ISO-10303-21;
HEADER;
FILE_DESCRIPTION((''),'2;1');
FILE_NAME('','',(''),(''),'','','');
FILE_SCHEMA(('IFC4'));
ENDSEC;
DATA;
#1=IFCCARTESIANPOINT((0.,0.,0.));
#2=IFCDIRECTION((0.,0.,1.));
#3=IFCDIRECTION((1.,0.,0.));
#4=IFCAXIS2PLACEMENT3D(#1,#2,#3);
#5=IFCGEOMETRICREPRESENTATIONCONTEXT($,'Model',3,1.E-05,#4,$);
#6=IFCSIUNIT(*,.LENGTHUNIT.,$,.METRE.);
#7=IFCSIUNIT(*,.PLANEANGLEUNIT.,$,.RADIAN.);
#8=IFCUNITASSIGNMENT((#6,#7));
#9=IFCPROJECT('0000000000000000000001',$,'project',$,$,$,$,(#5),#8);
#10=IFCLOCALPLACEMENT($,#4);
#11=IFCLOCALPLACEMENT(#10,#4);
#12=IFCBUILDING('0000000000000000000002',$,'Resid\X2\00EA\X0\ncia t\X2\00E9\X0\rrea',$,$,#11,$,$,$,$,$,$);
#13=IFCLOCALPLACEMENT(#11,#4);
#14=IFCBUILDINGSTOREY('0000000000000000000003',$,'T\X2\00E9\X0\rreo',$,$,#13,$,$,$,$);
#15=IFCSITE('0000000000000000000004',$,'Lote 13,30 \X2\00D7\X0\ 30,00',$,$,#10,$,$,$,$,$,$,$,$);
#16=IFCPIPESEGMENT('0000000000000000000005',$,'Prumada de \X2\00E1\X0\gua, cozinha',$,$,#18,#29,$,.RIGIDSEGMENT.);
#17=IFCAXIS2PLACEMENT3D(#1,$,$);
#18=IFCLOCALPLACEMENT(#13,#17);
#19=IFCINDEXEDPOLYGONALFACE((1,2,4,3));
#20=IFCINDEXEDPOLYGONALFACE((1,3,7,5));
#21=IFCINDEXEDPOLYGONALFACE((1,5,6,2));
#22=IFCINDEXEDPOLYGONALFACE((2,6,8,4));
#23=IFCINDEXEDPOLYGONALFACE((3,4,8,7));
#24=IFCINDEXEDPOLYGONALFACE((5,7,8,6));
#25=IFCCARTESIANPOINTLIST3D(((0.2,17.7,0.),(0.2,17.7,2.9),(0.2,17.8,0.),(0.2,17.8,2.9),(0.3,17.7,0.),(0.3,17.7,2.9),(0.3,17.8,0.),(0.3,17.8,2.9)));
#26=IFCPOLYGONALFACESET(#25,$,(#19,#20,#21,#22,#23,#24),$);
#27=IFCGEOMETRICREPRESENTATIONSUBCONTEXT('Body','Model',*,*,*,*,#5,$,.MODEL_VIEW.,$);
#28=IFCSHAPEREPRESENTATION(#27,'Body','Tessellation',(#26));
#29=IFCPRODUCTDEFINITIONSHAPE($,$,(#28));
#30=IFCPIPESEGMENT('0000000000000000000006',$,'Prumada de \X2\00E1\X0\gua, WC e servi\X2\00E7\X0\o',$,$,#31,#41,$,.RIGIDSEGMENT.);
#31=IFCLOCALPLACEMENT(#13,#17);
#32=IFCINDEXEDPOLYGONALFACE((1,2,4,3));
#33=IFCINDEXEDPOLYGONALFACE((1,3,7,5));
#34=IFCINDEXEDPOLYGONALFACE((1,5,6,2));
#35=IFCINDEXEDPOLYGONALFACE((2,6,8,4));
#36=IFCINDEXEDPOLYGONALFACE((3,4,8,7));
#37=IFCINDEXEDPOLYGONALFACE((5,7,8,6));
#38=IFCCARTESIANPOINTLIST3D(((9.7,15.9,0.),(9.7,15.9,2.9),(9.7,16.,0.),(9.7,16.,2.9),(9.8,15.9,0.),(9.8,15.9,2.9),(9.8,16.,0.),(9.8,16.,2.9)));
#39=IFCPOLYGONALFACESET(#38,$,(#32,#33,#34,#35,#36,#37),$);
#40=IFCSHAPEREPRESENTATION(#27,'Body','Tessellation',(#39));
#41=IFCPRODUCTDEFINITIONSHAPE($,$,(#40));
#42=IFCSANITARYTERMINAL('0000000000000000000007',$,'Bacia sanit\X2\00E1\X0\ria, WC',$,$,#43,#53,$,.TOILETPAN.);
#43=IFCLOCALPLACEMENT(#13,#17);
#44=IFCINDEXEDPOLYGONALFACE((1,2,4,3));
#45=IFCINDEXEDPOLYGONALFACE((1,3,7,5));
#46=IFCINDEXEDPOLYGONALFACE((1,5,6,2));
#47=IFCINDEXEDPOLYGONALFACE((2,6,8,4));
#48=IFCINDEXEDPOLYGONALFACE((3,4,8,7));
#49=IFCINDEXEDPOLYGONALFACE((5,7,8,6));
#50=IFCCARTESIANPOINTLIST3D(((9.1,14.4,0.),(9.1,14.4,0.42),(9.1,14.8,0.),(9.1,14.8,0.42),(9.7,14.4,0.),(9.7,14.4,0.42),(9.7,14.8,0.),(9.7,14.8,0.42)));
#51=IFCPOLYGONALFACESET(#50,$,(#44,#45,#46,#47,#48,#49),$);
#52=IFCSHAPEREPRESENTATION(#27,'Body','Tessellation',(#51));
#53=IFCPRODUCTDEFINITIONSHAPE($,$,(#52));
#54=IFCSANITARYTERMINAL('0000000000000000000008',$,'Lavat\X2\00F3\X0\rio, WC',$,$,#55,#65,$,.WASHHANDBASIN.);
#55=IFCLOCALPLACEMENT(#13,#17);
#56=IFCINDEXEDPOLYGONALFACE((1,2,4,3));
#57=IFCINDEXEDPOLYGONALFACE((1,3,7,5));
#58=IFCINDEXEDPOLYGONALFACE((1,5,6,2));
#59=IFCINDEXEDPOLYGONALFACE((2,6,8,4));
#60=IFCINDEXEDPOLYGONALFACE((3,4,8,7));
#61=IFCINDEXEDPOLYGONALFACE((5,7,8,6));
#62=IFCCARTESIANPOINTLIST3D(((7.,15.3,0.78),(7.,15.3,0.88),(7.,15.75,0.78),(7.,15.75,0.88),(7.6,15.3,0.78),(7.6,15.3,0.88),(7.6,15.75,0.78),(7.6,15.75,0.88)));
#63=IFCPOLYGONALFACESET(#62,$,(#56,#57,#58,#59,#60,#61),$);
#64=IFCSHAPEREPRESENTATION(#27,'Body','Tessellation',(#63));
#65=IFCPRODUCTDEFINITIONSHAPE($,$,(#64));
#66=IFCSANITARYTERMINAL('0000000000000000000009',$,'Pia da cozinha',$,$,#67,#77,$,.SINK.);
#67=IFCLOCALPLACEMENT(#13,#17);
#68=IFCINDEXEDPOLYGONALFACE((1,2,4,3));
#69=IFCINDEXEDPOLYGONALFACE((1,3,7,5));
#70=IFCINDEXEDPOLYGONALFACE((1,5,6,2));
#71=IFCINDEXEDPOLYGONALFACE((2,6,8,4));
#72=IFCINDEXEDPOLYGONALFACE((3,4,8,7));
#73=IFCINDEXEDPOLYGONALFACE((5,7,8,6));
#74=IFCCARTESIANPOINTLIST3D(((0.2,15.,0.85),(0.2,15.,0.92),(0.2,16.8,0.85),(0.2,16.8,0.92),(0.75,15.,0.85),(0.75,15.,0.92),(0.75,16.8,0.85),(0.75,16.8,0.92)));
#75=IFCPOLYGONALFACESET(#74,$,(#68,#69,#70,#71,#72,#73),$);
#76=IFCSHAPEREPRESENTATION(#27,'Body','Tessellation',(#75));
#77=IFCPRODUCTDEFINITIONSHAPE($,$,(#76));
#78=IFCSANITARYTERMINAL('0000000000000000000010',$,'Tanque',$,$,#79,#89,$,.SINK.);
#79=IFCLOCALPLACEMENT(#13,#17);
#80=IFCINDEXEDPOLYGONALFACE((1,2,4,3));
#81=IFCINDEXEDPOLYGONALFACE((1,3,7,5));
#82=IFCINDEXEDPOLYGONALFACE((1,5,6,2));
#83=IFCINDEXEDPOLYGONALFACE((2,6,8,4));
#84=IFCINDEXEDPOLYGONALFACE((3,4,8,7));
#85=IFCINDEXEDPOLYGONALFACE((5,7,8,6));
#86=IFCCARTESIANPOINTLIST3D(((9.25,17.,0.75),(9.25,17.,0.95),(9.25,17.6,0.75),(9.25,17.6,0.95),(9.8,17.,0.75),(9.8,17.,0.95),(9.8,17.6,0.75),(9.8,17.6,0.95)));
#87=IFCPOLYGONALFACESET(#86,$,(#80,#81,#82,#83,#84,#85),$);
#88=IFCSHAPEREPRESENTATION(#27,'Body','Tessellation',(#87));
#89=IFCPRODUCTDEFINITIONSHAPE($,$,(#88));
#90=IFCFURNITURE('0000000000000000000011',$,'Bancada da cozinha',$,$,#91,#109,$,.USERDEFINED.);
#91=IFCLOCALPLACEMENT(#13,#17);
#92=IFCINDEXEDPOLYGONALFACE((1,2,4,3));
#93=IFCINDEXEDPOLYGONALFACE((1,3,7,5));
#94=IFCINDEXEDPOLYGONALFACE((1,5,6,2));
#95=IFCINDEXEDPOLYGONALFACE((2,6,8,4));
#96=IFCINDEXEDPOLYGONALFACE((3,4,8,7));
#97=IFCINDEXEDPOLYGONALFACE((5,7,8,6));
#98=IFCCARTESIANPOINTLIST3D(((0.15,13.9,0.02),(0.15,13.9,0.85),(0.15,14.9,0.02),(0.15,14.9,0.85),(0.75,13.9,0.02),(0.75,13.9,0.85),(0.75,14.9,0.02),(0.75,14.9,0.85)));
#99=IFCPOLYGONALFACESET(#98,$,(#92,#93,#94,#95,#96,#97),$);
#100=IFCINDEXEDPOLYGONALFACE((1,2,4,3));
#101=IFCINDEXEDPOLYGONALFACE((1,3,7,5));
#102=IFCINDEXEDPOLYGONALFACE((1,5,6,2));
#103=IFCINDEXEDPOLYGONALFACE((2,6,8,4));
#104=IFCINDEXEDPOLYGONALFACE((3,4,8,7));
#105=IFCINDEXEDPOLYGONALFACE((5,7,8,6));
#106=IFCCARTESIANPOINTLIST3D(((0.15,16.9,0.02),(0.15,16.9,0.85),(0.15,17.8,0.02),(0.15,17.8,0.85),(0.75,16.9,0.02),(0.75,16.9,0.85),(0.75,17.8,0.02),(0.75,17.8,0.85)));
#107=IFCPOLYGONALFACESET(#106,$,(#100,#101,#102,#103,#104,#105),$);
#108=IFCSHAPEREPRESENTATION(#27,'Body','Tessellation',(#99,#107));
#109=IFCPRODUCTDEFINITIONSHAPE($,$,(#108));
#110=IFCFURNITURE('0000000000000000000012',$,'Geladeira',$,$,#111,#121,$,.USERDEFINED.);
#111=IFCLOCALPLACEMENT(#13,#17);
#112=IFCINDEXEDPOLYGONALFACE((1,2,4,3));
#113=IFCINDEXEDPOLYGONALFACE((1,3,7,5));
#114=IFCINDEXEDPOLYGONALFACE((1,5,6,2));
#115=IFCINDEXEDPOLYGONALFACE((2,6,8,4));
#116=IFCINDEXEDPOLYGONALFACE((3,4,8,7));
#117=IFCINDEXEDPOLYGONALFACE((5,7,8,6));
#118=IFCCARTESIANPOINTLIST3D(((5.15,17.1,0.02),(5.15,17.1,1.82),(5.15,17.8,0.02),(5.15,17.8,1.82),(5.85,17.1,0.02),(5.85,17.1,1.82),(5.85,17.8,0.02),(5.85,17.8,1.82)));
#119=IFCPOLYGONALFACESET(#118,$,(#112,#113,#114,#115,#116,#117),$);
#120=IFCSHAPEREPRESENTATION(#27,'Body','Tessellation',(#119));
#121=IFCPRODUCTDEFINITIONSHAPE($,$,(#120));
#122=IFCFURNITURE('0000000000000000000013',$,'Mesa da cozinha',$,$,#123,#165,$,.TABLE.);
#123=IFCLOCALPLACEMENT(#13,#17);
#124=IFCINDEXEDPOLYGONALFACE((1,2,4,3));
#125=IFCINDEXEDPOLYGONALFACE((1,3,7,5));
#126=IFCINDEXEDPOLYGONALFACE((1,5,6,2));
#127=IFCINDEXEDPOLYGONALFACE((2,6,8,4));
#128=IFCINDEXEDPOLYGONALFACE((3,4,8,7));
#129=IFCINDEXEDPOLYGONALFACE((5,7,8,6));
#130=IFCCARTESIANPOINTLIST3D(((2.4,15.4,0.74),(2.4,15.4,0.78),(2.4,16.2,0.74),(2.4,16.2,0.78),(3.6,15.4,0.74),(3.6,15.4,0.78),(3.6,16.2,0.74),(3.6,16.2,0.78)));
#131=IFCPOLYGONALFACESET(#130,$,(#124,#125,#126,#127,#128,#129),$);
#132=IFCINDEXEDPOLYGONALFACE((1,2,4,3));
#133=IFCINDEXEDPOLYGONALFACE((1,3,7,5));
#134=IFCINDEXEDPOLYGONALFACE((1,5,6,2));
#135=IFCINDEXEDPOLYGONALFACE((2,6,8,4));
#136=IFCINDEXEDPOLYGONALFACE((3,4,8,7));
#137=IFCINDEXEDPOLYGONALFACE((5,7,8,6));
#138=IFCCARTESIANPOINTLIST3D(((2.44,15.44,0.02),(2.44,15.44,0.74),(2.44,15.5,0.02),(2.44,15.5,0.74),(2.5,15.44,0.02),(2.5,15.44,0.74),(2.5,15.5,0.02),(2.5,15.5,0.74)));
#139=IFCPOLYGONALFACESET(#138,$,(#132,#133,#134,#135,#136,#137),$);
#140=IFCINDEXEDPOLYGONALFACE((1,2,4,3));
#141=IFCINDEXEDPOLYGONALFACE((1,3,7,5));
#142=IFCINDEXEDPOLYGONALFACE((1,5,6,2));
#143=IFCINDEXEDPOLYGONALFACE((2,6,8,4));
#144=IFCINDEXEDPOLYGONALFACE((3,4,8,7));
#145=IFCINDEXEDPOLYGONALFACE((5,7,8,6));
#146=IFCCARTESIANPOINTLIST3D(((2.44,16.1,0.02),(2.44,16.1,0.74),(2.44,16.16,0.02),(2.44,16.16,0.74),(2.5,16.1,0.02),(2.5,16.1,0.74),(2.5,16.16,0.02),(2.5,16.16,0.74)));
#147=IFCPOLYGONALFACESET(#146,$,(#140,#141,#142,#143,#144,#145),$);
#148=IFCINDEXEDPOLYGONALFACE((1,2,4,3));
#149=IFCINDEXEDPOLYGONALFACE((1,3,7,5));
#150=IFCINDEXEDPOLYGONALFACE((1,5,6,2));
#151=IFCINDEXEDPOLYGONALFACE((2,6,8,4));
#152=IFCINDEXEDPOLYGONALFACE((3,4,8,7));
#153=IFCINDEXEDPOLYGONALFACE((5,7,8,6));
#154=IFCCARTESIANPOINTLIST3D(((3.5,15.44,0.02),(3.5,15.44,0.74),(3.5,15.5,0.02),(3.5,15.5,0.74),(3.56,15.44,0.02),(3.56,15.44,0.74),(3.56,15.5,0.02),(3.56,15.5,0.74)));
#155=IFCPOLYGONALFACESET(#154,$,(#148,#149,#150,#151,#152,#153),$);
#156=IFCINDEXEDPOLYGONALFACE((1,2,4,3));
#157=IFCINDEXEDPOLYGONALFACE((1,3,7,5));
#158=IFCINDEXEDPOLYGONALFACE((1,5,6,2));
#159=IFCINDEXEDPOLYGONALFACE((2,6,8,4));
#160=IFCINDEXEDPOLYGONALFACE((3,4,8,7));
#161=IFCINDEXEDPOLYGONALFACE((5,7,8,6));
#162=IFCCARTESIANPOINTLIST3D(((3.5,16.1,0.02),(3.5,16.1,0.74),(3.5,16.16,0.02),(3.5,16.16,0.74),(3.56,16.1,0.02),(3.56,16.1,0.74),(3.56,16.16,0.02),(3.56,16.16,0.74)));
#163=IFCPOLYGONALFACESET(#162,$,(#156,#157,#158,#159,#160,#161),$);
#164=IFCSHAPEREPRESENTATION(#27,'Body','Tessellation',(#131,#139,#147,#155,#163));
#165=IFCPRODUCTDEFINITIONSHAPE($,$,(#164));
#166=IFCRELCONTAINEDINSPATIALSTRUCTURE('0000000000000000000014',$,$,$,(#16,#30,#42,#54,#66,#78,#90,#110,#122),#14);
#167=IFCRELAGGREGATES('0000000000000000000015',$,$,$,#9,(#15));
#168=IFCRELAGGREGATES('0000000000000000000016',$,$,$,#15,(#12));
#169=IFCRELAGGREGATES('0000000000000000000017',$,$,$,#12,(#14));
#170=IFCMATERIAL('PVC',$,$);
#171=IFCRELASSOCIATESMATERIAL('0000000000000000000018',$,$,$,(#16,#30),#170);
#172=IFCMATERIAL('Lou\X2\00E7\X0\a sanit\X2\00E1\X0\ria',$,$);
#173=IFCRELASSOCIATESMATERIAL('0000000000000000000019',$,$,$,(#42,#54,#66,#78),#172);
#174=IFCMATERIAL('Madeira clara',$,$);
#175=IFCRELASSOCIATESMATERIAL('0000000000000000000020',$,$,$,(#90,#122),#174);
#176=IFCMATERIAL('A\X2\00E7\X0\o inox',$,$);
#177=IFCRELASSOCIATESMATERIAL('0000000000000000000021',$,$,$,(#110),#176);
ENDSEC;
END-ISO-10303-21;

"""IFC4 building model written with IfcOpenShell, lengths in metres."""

from ifc_helpers import new_model, si_unit, frame, origin_with_axes, place, context, subcontext, project, spatial, line, indexed_curve, outline, extrude, material, element, save


model = new_model("IFC4")

# Units and contexts
model_context = context("Model", 3, precision=1e-05, world=origin_with_axes())
body_context = subcontext(model_context, "Body", "Model", "MODEL_VIEW")
ifc_project = project(units=[si_unit("LENGTHUNIT", "METRE"), si_unit("PLANEANGLEUNIT", "RADIAN")], contexts=[model_context])

# Site, building, storey
site_placement = place(None, origin_with_axes())
site = spatial("IfcSite", under=ifc_project, at=site_placement, Name="Lote 13,30 × 30,00")
building_placement = place(site_placement, origin_with_axes())
building = spatial("IfcBuilding", under=site, at=building_placement, Name="Residência térrea")
storey_placement = place(building_placement, origin_with_axes())
storey = spatial("IfcBuildingStorey", under=building, at=storey_placement, Name="Térreo")

# Pipe segments
ifc_material_1 = material(Name="PVC")
pipe_segment_1_placement = place(storey_placement, frame((0.2, 17.7, 0.0), z_axis=(0.0, 0.0, 1.0), x_axis=(1.0, 0.0, 0.0)))
element("IfcPipeSegment", 1, at=pipe_segment_1_placement, inside=storey, material=ifc_material_1, Name="Prumada de água, cozinha", PredefinedType="RIGIDSEGMENT", context=body_context, shape_type="SweptSolid", body=[
    extrude(outline(indexed_curve([(0.0, 0.0), (0.1, 0.0), (0.1, 0.1), (0.0, 0.1)], segments=[line(1, 2, 3, 4, 1)])), origin_with_axes(), (0.0, 0.0, 1.0), 2.9),
])
pipe_segment_2_placement = place(storey_placement, frame((9.7, 15.9, 0.0), z_axis=(0.0, 0.0, 1.0), x_axis=(1.0, 0.0, 0.0)))
element("IfcPipeSegment", 2, at=pipe_segment_2_placement, inside=storey, material=ifc_material_1, Name="Prumada de água, WC e serviço", PredefinedType="RIGIDSEGMENT", context=body_context, shape_type="SweptSolid", body=[
    extrude(outline(indexed_curve([(0.0, 0.0), (0.1, 0.0), (0.1, 0.1), (0.0, 0.1)], segments=[line(1, 2, 3, 4, 1)])), origin_with_axes(), (0.0, 0.0, 1.0), 2.9),
])

# Sanitary terminals
ifc_material_2 = material(Name="Louça sanitária")
sanitary_terminal_1_placement = place(storey_placement, frame((9.1, 14.4, 0.0), z_axis=(0.0, 0.0, 1.0), x_axis=(1.0, 0.0, 0.0)))
element("IfcSanitaryTerminal", 3, at=sanitary_terminal_1_placement, inside=storey, material=ifc_material_2, Name="Bacia sanitária, WC", PredefinedType="TOILETPAN", context=body_context, shape_type="SweptSolid", body=[
    extrude(outline(indexed_curve([(0.0, 0.0), (0.6, 0.0), (0.6, 0.4), (0.0, 0.4)], segments=[line(1, 2, 3, 4, 1)])), origin_with_axes(), (0.0, 0.0, 1.0), 0.42),
])
sanitary_terminal_2_placement = place(storey_placement, frame((7.0, 15.3, 0.78), z_axis=(0.0, 0.0, 1.0), x_axis=(1.0, 0.0, 0.0)))
element("IfcSanitaryTerminal", 4, at=sanitary_terminal_2_placement, inside=storey, material=ifc_material_2, Name="Lavatório, WC", PredefinedType="WASHHANDBASIN", context=body_context, shape_type="SweptSolid", body=[
    extrude(outline(indexed_curve([(0.0, 0.0), (0.6, 0.0), (0.6, 0.45), (0.0, 0.45)], segments=[line(1, 2, 3, 4, 1)])), origin_with_axes(), (0.0, 0.0, 1.0), 0.1),
])
sanitary_terminal_3_placement = place(storey_placement, frame((0.2, 15.0, 0.85), z_axis=(0.0, 0.0, 1.0), x_axis=(1.0, 0.0, 0.0)))
element("IfcSanitaryTerminal", 5, at=sanitary_terminal_3_placement, inside=storey, material=ifc_material_2, Name="Pia da cozinha", PredefinedType="SINK", context=body_context, shape_type="SweptSolid", body=[
    extrude(outline(indexed_curve([(0.0, 0.0), (0.55, 0.0), (0.55, 1.8), (0.0, 1.8)], segments=[line(1, 2, 3, 4, 1)])), origin_with_axes(), (0.0, 0.0, 1.0), 0.07),
])
sanitary_terminal_4_placement = place(storey_placement, frame((9.25, 17.0, 0.75), z_axis=(0.0, 0.0, 1.0), x_axis=(1.0, 0.0, 0.0)))
element("IfcSanitaryTerminal", 6, at=sanitary_terminal_4_placement, inside=storey, material=ifc_material_2, Name="Tanque", PredefinedType="SINK", context=body_context, shape_type="SweptSolid", body=[
    extrude(outline(indexed_curve([(0.0, 0.0), (0.55, 0.0), (0.55, 0.6), (0.0, 0.6)], segments=[line(1, 2, 3, 4, 1)])), origin_with_axes(), (0.0, 0.0, 1.0), 0.2),
])

# Furniture
ifc_material_3 = material(Name="Madeira clara")
furniture_1_placement = place(storey_placement, frame((0.15, 13.9, 0.02), z_axis=(0.0, 0.0, 1.0), x_axis=(1.0, 0.0, 0.0)))
element("IfcFurniture", 7, at=furniture_1_placement, inside=storey, material=ifc_material_3, Name="Bancada da cozinha", PredefinedType="USERDEFINED", context=body_context, shape_type="SweptSolid", body=[
    extrude(outline(indexed_curve([(0.0, 0.0), (0.6, 0.0), (0.6, 1.0), (0.0, 1.0)], segments=[line(1, 2, 3, 4, 1)])), origin_with_axes(), (0.0, 0.0, 1.0), 0.83),
    extrude(outline(indexed_curve([(0.0, 3.0), (0.6, 3.0), (0.6, 3.9), (0.0, 3.9)], segments=[line(1, 2, 3, 4, 1)])), origin_with_axes(), (0.0, 0.0, 1.0), 0.83),
])
ifc_material_4 = material(Name="Aço inox")
furniture_2_placement = place(storey_placement, frame((5.15, 17.1, 0.02), z_axis=(0.0, 0.0, 1.0), x_axis=(1.0, 0.0, 0.0)))
element("IfcFurniture", 8, at=furniture_2_placement, inside=storey, material=ifc_material_4, Name="Geladeira", PredefinedType="USERDEFINED", context=body_context, shape_type="SweptSolid", body=[
    extrude(outline(indexed_curve([(0.0, 0.0), (0.7, 0.0), (0.7, 0.7), (0.0, 0.7)], segments=[line(1, 2, 3, 4, 1)])), origin_with_axes(), (0.0, 0.0, 1.0), 1.8),
])
furniture_3_placement = place(storey_placement, frame((2.4, 15.4, 0.02), z_axis=(0.0, 0.0, 1.0), x_axis=(1.0, 0.0, 0.0)))
element("IfcFurniture", 9, at=furniture_3_placement, inside=storey, material=ifc_material_3, Name="Mesa da cozinha", PredefinedType="TABLE", context=body_context, shape_type="SweptSolid", body=[
    extrude(outline(indexed_curve([(0.0, 0.0), (1.2, 0.0), (1.2, 0.8), (0.0, 0.8)], segments=[line(1, 2, 3, 4, 1)])), frame((0.0, 0.0, 0.72), z_axis=(0.0, 0.0, 1.0), x_axis=(1.0, 0.0, 0.0)), (0.0, 0.0, 1.0), 0.04),
    extrude(outline(indexed_curve([(0.04, 0.04), (0.1, 0.04), (0.1, 0.1), (0.04, 0.1)], segments=[line(1, 2, 3, 4, 1)])), origin_with_axes(), (0.0, 0.0, 1.0), 0.72),
    extrude(outline(indexed_curve([(0.04, 0.7), (0.1, 0.7), (0.1, 0.76), (0.04, 0.76)], segments=[line(1, 2, 3, 4, 1)])), origin_with_axes(), (0.0, 0.0, 1.0), 0.72),
    extrude(outline(indexed_curve([(1.1, 0.04), (1.16, 0.04), (1.16, 0.1), (1.1, 0.1)], segments=[line(1, 2, 3, 4, 1)])), origin_with_axes(), (0.0, 0.0, 1.0), 0.72),
    extrude(outline(indexed_curve([(1.1, 0.7), (1.16, 0.7), (1.16, 0.76), (1.1, 0.76)], segments=[line(1, 2, 3, 4, 1)])), origin_with_axes(), (0.0, 0.0, 1.0), 0.72),
])

save(model, "model.ifc")
